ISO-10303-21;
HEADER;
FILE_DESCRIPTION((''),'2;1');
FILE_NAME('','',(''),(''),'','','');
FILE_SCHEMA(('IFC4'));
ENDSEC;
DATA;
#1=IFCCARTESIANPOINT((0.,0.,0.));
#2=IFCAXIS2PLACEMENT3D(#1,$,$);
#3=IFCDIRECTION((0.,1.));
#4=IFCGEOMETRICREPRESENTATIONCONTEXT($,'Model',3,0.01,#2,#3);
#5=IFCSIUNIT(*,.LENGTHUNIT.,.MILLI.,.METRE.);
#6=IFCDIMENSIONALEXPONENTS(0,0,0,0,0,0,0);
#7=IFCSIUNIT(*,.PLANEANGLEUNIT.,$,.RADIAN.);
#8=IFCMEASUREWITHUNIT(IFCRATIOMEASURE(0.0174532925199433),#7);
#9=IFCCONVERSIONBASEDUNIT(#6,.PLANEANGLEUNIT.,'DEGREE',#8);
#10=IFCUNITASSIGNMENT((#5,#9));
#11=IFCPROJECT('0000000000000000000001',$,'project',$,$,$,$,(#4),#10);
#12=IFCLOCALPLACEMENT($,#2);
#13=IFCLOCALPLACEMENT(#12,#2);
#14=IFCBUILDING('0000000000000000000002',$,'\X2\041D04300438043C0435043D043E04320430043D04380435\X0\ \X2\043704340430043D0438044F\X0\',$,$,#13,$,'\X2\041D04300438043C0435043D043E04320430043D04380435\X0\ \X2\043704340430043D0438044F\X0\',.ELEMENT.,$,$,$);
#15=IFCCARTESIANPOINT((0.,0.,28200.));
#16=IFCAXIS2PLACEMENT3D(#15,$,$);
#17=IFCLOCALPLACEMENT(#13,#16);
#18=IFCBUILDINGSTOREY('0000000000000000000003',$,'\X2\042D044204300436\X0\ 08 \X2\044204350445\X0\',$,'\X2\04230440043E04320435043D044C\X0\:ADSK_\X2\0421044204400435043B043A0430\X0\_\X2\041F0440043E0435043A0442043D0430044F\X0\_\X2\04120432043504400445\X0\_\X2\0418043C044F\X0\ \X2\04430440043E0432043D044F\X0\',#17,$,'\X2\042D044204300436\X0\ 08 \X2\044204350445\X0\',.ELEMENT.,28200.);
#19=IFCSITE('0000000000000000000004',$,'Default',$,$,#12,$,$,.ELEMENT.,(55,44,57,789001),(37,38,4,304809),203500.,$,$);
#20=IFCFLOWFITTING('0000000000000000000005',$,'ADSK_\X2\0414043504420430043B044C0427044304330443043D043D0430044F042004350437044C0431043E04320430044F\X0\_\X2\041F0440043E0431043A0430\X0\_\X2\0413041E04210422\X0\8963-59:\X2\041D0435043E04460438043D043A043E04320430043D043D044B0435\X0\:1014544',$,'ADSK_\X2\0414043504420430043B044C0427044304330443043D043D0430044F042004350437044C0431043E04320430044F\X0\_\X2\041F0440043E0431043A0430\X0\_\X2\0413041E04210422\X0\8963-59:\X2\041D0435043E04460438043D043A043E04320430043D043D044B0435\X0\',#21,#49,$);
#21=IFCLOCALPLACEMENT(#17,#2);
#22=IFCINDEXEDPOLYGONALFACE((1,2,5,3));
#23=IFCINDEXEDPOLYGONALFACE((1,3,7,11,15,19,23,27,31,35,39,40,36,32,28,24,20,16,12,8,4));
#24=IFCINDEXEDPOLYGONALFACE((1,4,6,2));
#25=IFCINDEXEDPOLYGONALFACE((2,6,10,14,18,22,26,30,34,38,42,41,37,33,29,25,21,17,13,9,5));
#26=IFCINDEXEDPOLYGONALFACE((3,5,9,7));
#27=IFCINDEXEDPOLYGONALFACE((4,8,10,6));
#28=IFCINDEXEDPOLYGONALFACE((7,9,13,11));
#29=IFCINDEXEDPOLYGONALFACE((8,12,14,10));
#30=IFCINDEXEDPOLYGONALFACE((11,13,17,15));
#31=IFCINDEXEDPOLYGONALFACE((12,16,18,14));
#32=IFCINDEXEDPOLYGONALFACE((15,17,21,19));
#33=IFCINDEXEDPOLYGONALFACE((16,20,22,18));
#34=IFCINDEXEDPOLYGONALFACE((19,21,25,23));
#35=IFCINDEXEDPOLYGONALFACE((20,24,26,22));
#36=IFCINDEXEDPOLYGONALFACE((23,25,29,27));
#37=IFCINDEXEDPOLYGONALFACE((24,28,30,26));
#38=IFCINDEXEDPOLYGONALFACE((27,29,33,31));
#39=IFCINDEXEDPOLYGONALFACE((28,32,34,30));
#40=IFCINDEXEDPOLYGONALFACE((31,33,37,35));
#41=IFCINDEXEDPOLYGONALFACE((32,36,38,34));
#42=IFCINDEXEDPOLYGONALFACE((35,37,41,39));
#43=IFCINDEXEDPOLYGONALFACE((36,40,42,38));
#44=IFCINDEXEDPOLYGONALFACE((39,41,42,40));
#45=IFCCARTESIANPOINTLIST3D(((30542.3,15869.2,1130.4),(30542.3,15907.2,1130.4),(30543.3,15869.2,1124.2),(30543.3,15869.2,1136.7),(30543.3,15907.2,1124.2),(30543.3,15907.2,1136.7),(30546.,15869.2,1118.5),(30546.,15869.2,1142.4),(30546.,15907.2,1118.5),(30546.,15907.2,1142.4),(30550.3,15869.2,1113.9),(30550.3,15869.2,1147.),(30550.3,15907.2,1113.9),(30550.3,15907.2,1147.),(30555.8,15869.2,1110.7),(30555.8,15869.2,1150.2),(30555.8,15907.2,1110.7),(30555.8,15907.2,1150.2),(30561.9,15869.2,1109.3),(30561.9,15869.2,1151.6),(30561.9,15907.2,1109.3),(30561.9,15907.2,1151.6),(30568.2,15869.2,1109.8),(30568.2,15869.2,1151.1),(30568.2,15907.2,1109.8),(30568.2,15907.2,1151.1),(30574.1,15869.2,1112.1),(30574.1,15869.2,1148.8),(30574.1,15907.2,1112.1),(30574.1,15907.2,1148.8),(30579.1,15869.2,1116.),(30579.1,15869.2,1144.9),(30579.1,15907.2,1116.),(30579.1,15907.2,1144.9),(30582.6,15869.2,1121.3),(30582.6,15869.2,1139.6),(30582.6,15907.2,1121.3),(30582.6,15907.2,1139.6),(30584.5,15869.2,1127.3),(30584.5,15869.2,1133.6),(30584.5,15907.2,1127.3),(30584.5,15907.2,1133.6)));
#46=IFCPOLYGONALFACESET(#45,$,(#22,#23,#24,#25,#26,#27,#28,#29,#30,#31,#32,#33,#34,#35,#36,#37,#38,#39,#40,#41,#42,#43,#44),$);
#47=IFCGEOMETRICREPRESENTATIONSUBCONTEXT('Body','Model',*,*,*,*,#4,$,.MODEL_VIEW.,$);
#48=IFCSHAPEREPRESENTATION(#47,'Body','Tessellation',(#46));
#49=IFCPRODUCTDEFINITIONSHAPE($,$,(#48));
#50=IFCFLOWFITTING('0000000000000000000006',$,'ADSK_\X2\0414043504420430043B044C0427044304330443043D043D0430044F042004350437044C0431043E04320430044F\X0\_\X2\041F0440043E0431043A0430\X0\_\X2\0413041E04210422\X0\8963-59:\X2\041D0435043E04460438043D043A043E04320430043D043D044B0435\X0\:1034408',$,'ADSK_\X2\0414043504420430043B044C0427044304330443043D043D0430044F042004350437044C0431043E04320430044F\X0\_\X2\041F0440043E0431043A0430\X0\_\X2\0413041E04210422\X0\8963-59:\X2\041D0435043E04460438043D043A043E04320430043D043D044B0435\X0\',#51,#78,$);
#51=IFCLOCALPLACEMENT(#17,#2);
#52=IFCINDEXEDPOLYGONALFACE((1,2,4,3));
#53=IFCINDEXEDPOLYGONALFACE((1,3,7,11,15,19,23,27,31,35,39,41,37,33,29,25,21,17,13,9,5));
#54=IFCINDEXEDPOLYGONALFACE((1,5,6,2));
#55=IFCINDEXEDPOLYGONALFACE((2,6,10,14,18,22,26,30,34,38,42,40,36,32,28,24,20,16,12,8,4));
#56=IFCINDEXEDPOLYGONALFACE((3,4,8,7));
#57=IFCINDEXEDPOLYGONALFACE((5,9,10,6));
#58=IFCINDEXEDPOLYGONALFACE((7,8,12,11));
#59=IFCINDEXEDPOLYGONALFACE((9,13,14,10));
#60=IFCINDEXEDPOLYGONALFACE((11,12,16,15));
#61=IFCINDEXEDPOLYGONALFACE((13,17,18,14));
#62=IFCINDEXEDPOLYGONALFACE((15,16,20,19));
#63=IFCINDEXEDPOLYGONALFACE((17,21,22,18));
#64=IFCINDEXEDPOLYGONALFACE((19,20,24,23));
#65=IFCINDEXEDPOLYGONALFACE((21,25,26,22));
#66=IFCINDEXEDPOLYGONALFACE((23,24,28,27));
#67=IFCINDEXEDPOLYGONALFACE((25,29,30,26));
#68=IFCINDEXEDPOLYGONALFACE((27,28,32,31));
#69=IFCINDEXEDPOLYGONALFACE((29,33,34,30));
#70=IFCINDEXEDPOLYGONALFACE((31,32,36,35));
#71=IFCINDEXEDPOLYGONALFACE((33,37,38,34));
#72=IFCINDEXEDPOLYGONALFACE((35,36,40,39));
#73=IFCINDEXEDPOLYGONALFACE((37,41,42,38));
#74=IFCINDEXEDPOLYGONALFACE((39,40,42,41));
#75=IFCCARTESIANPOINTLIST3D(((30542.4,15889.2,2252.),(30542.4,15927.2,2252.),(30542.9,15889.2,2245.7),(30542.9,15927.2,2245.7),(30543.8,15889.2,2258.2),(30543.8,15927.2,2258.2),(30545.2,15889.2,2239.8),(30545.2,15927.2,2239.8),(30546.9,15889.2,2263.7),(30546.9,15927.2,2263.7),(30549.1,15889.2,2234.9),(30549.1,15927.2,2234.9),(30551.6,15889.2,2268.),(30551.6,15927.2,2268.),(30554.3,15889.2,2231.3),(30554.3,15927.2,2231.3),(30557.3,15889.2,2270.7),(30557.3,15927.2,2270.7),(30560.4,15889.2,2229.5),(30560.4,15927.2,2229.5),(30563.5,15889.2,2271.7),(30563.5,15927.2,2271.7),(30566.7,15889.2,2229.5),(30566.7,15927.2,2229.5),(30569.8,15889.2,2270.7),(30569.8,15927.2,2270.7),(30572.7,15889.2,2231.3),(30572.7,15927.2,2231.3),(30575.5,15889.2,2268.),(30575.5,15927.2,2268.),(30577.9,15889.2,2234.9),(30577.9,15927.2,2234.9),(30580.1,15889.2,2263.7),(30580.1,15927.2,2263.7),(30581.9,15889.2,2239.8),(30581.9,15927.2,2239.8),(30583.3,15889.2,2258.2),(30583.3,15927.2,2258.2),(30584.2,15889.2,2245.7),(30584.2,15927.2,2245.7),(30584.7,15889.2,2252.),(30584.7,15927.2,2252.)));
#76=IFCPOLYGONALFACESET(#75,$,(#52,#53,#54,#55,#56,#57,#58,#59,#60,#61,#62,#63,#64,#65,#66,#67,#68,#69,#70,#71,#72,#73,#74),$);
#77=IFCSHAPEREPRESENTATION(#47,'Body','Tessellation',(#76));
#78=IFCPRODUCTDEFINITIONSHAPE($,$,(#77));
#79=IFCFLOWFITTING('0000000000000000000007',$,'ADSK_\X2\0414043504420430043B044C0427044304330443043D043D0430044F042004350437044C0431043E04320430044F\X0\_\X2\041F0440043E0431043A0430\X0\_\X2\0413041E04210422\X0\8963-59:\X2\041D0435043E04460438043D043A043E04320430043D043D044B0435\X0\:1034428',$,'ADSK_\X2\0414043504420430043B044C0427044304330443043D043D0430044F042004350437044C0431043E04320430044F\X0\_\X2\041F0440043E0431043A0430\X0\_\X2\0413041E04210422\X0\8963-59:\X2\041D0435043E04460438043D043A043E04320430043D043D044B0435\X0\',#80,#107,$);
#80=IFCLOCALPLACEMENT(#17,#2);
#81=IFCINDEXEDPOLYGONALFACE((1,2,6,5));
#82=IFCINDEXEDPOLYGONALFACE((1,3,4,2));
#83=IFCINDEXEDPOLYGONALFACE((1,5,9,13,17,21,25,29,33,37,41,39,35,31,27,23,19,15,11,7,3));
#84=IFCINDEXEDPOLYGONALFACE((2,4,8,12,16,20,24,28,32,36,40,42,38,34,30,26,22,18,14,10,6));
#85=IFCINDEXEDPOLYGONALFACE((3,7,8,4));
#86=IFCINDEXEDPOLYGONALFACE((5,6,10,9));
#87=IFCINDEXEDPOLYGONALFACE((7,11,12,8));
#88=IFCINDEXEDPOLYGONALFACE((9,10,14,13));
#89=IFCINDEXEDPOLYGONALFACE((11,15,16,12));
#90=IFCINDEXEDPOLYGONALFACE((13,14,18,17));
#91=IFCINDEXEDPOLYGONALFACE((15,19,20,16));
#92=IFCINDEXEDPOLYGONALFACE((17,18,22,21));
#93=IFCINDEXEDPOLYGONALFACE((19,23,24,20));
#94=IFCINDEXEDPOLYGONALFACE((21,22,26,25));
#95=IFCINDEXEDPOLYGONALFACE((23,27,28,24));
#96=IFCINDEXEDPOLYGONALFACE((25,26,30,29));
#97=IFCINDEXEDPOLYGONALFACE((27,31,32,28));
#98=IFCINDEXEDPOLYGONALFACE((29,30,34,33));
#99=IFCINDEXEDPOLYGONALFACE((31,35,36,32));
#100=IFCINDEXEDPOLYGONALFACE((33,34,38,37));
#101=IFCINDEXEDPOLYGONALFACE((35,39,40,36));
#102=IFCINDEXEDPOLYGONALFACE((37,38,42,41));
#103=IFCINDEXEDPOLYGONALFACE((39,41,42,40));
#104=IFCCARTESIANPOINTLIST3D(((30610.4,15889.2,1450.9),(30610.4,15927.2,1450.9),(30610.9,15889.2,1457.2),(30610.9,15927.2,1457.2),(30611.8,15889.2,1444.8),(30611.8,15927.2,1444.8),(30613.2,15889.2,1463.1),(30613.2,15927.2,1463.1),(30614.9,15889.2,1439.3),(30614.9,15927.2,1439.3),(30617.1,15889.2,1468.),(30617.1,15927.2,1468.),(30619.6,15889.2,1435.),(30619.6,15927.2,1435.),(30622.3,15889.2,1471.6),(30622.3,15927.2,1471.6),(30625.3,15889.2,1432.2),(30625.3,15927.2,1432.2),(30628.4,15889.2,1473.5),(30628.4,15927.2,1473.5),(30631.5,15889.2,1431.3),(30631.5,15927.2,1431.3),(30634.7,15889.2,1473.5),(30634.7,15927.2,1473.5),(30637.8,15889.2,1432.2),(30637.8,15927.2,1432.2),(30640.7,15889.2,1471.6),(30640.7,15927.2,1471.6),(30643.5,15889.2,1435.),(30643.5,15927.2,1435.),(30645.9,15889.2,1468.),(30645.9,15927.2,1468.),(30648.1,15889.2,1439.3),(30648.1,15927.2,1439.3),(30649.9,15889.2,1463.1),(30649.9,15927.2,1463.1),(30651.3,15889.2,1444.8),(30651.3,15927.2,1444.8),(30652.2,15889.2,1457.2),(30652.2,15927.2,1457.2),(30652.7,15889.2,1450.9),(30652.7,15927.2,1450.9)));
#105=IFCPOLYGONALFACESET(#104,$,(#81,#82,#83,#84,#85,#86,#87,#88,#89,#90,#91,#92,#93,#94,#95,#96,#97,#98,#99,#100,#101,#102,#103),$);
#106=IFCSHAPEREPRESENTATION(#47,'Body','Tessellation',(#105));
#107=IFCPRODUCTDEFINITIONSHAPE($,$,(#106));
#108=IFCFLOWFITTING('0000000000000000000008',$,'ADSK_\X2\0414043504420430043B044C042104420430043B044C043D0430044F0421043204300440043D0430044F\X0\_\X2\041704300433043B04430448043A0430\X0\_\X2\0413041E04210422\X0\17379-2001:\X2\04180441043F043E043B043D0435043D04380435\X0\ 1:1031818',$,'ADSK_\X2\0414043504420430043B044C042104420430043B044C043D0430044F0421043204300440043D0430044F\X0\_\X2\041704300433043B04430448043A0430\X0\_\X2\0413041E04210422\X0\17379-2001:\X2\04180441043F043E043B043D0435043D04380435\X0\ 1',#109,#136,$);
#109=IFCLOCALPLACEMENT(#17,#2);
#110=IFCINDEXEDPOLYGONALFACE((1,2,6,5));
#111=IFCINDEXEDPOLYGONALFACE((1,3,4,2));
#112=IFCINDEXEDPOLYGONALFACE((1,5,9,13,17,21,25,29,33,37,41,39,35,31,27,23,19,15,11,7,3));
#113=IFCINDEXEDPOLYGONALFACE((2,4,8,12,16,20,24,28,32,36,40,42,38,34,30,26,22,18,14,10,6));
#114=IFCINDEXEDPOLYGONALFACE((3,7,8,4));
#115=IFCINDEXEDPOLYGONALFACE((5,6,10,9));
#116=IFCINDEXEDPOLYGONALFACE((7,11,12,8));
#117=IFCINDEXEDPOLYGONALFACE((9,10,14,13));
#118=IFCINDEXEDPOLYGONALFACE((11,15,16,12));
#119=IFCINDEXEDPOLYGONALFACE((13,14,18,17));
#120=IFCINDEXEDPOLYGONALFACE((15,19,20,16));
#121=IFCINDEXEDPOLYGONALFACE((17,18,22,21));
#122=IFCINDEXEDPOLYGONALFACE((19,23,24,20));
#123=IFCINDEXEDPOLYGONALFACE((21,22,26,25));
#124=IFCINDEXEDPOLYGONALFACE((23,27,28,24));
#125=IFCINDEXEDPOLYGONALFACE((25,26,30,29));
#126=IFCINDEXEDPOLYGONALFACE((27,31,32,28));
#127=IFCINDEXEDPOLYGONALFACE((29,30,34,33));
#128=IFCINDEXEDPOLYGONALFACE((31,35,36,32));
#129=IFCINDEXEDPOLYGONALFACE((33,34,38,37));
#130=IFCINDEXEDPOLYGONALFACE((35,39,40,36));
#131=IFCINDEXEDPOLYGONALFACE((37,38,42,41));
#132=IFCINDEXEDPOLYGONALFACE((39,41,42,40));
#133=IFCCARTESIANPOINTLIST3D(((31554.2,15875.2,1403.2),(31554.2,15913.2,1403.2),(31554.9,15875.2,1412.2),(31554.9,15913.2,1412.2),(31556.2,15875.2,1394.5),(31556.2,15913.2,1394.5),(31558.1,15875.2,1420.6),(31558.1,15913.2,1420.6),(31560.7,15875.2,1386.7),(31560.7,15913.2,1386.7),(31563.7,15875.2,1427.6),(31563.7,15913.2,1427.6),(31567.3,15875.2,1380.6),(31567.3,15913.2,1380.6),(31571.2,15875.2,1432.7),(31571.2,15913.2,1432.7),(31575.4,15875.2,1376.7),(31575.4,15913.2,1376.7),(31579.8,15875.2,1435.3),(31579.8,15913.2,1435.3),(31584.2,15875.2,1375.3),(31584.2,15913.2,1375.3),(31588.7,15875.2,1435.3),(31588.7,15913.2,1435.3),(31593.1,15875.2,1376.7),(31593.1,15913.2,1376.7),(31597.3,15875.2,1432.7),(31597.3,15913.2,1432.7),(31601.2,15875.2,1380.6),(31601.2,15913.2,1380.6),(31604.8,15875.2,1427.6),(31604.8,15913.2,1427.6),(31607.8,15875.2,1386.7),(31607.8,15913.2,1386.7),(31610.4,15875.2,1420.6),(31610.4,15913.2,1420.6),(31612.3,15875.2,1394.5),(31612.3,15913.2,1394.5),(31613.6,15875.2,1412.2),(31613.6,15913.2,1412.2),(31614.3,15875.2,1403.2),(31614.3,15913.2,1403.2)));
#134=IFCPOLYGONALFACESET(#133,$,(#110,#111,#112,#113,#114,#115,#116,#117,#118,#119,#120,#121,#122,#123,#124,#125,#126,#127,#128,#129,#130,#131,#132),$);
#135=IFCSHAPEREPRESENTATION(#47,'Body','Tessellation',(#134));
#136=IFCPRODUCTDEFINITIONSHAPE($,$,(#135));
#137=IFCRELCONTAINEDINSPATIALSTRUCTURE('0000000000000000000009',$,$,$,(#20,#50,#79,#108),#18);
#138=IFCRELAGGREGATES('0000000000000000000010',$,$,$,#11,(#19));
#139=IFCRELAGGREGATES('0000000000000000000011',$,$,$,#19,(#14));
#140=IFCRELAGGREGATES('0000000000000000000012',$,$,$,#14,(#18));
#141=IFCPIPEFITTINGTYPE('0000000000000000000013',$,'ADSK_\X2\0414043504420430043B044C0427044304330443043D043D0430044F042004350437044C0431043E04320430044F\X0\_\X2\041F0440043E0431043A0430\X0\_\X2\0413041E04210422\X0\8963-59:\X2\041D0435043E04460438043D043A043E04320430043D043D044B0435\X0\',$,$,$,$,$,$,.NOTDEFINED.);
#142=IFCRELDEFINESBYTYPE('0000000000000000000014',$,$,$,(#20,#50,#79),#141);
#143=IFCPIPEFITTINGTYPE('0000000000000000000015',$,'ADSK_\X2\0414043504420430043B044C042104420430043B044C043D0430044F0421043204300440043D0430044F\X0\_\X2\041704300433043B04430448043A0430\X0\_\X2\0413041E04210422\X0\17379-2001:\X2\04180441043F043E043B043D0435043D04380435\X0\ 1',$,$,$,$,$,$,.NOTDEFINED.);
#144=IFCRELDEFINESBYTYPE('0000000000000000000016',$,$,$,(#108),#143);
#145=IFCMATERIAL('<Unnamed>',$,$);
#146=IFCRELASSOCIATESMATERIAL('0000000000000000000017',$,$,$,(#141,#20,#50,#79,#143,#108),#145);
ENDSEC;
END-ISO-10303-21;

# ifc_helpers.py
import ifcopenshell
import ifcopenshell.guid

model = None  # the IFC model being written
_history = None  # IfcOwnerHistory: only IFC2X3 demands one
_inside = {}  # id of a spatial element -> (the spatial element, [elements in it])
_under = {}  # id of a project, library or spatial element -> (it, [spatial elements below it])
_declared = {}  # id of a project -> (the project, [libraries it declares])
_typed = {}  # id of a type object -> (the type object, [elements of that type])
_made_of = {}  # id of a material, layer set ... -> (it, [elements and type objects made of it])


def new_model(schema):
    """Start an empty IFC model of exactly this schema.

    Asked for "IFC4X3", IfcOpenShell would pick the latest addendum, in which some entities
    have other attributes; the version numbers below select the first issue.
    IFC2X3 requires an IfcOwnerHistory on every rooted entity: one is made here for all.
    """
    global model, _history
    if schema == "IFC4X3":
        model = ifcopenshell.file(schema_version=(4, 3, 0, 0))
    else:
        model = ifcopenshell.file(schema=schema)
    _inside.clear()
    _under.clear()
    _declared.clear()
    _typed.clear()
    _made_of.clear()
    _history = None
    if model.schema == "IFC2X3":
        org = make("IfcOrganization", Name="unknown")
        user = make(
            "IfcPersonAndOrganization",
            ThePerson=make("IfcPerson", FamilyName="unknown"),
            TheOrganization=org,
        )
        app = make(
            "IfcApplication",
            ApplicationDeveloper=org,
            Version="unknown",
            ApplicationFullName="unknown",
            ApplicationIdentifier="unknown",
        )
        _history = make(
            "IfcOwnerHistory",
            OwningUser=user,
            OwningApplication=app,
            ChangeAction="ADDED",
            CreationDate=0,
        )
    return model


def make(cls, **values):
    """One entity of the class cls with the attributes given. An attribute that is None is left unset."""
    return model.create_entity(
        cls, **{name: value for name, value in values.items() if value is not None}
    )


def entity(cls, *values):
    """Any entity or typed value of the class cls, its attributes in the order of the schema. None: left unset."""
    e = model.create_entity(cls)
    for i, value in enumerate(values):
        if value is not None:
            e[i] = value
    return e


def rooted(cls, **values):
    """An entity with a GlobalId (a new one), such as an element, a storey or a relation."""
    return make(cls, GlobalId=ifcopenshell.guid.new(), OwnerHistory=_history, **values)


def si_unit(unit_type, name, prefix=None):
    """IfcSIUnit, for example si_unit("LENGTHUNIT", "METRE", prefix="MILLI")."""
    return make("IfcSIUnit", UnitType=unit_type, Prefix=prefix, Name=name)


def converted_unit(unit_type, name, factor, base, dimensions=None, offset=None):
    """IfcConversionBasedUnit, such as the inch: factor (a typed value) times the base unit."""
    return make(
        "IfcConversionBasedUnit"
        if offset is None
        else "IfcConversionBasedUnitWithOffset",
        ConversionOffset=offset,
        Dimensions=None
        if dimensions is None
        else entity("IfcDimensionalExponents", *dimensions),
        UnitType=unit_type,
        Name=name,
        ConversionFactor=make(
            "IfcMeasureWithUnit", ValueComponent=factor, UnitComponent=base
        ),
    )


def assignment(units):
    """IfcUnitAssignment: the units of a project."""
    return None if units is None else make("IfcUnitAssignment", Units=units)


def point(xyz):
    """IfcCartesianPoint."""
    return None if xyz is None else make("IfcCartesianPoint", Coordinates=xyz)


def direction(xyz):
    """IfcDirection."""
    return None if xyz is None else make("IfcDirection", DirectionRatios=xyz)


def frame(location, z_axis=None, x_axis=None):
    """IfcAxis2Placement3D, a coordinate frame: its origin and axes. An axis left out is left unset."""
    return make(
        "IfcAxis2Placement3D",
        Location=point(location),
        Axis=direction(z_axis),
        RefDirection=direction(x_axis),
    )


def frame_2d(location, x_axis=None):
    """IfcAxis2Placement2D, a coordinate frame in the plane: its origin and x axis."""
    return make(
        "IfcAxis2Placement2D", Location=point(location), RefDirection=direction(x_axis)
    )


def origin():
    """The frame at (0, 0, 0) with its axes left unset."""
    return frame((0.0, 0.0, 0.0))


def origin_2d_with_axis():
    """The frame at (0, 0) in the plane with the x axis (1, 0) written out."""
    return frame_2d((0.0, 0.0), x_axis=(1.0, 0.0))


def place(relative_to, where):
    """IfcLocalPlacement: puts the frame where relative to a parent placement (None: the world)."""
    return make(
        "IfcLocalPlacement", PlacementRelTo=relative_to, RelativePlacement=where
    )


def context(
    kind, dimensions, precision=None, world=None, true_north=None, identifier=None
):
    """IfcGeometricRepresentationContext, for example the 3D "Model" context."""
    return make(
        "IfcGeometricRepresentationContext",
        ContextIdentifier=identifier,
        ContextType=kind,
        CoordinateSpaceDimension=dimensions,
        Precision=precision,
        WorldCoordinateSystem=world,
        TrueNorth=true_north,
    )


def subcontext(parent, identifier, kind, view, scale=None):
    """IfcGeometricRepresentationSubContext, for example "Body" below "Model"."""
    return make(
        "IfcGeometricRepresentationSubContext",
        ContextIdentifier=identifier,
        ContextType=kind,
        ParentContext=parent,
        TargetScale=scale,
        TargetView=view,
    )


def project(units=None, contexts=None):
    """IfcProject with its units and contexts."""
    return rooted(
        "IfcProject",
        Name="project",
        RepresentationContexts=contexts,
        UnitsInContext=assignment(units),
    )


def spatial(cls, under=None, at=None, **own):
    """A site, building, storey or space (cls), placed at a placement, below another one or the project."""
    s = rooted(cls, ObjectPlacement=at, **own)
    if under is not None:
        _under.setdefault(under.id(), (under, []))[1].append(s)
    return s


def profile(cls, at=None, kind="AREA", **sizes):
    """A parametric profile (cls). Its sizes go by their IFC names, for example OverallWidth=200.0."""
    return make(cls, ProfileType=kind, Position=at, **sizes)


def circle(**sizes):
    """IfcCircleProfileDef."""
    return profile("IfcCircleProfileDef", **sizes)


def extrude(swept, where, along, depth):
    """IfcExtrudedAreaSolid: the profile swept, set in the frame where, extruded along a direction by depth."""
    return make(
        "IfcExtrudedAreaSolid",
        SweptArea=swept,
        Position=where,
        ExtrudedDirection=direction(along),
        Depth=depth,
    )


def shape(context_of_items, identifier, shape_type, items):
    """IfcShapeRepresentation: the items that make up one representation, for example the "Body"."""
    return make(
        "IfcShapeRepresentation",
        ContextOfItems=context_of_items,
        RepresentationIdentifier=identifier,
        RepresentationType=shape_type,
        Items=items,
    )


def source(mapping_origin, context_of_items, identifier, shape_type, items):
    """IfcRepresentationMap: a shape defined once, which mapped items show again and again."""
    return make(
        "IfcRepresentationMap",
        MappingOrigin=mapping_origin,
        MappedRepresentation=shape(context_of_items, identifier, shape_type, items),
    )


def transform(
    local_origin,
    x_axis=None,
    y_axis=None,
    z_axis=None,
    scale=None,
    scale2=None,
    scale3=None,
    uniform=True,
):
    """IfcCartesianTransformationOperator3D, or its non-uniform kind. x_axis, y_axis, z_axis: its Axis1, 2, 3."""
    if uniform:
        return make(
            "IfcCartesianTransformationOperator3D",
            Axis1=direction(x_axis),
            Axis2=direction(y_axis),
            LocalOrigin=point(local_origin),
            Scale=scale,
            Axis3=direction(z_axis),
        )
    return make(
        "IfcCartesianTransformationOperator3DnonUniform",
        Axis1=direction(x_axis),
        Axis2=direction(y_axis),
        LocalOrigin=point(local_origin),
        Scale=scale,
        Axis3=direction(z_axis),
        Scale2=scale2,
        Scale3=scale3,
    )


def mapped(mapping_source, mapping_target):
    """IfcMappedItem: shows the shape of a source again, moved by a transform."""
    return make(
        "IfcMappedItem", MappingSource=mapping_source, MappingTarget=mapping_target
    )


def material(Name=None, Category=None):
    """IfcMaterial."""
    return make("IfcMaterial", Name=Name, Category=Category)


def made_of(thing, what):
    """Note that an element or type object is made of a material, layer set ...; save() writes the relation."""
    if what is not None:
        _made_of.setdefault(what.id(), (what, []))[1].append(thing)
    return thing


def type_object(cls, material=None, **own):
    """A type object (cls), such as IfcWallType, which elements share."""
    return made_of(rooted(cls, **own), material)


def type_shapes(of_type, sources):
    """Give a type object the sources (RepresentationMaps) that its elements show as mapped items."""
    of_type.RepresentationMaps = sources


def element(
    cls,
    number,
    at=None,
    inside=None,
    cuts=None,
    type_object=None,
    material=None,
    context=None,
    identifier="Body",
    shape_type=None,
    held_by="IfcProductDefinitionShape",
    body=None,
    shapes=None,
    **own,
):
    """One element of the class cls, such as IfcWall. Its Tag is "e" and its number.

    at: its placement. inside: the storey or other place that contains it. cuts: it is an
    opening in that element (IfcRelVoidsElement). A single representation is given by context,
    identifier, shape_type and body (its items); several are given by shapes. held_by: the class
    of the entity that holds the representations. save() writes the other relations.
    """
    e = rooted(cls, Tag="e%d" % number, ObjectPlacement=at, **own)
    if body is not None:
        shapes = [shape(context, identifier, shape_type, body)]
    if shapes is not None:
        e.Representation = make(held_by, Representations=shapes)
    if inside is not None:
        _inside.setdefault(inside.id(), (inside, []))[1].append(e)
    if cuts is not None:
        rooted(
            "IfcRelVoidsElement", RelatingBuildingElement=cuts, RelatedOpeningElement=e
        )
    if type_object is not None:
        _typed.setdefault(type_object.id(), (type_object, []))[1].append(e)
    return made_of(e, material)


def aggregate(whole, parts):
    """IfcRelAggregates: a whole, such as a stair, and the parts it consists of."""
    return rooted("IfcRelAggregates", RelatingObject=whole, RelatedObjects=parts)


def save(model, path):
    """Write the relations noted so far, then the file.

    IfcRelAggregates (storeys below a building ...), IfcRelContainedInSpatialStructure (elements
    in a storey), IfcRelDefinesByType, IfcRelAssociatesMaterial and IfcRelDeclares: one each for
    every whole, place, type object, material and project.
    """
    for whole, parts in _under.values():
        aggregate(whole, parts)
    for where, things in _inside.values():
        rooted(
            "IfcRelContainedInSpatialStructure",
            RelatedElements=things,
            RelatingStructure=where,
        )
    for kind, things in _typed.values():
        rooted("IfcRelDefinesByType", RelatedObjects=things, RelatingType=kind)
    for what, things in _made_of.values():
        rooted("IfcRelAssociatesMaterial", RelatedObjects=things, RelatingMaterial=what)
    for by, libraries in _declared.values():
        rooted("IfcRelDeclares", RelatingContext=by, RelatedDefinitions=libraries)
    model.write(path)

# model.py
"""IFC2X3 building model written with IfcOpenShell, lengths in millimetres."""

from ifc_helpers import new_model, entity, si_unit, converted_unit, direction, frame, origin, origin_2d_with_axis, place, context, subcontext, project, spatial, circle, extrude, source, transform, mapped, material, type_object, type_shapes, element, save


model = new_model("IFC2X3")

# Units and contexts
model_context = context("Model", 3, precision=0.01, world=origin(), true_north=direction((0.0, 1.0)))
body_context = subcontext(model_context, "Body", "Model", "MODEL_VIEW")
ifc_project = project(units=[si_unit("LENGTHUNIT", "METRE", prefix="MILLI"), converted_unit("PLANEANGLEUNIT", "DEGREE", entity("IfcRatioMeasure", 0.0174532925199433), si_unit("PLANEANGLEUNIT", "RADIAN"), dimensions=[0, 0, 0, 0, 0, 0, 0])], contexts=[model_context])

# Site, building, storey
site_placement = place(None, origin())
site = spatial("IfcSite", under=ifc_project, at=site_placement, Name="Default", CompositionType="ELEMENT", RefLatitude=(55, 44, 57, 789001), RefLongitude=(37, 38, 4, 304809), RefElevation=203500.0)
building_placement = place(site_placement, origin())
building = spatial("IfcBuilding", under=site, at=building_placement, Name="Наименование здания", LongName="Наименование здания", CompositionType="ELEMENT")
storey_placement = place(building_placement, frame((0.0, 0.0, 28200.0)))
storey = spatial("IfcBuildingStorey", under=building, at=storey_placement, Name="Этаж 08 тех", ObjectType="Уровень:ADSK_Стрелка_Проектная_Вверх_Имя уровня", LongName="Этаж 08 тех", CompositionType="ELEMENT", Elevation=28200.0)

# Shared definitions
ifc_material = material(Name="<Unnamed>")

# Flow fittings
pipe_fitting_type_1 = type_object("IfcPipeFittingType", Name="ADSK_ДетальЧугуннаяРезьбовая_Пробка_ГОСТ8963-59:Неоцинкованные", PredefinedType="NOTDEFINED", material=ifc_material)
shared_shape_1 = source(origin(), body_context, "Body", "SweptSolid", [
    extrude(circle(Radius=21.2, at=origin_2d_with_axis()), frame((0.0, 0.0, 0.0), z_axis=(1.0, 0.0, 0.0), x_axis=(0.0, 1.0, 0.0)), (0.0, 0.0, 1.0), 38.0),
])
type_shapes(pipe_fitting_type_1, [shared_shape_1])
for number, where, z_axis, x_axis, name in (
    (1, (30563.5, 15869.2, 1130.5), (0.0, 0.0, 1.0), (0.0, 1.0, 0.0), "ADSK_ДетальЧугуннаяРезьбовая_Пробка_ГОСТ8963-59:Неоцинкованные:1014544"),
    (2, (30563.5, 15889.2, 2250.4), (1.0, 0.0, 0.0), (0.0, 1.0, 0.0), "ADSK_ДетальЧугуннаяРезьбовая_Пробка_ГОСТ8963-59:Неоцинкованные:1034408"),
    (3, (30631.5, 15889.2, 1452.5), (-1.0, 0.0, 0.0), (0.0, 1.0, 0.0), "ADSK_ДетальЧугуннаяРезьбовая_Пробка_ГОСТ8963-59:Неоцинкованные:1034428"),
):
    element("IfcFlowFitting", number, at=place(storey_placement, frame(where, z_axis=z_axis, x_axis=x_axis)), inside=storey, type_object=pipe_fitting_type_1, material=ifc_material, Name=name, ObjectType="ADSK_ДетальЧугуннаяРезьбовая_Пробка_ГОСТ8963-59:Неоцинкованные", context=body_context, shape_type="MappedRepresentation", body=[
        mapped(shared_shape_1, transform((0.0, 0.0, 0.0), scale=1.0)),
    ])
pipe_fitting_type_2 = type_object("IfcPipeFittingType", Name="ADSK_ДетальСтальнаяСварная_Заглушка_ГОСТ17379-2001:Исполнение 1", PredefinedType="NOTDEFINED", material=ifc_material)
shared_shape_2 = source(origin(), body_context, "Body", "SweptSolid", [
    extrude(circle(Radius=30.1, at=origin_2d_with_axis()), frame((0.0, 0.0, 0.0), z_axis=(1.0, 0.0, 0.0), x_axis=(0.0, 1.0, 0.0)), (0.0, 0.0, 1.0), 38.0),
])
type_shapes(pipe_fitting_type_2, [shared_shape_2])
flow_fitting_placement = place(storey_placement, frame((31584.2, 15875.2, 1405.5), z_axis=(-1.0, 0.0, 0.0), x_axis=(0.0, 1.0, 0.0)))
element("IfcFlowFitting", 4, at=flow_fitting_placement, inside=storey, type_object=pipe_fitting_type_2, material=ifc_material, Name="ADSK_ДетальСтальнаяСварная_Заглушка_ГОСТ17379-2001:Исполнение 1:1031818", ObjectType="ADSK_ДетальСтальнаяСварная_Заглушка_ГОСТ17379-2001:Исполнение 1", context=body_context, shape_type="MappedRepresentation", body=[
    mapped(shared_shape_2, transform((0.0, 0.0, 0.0), scale=1.0)),
])

save(model, "model.ifc")
